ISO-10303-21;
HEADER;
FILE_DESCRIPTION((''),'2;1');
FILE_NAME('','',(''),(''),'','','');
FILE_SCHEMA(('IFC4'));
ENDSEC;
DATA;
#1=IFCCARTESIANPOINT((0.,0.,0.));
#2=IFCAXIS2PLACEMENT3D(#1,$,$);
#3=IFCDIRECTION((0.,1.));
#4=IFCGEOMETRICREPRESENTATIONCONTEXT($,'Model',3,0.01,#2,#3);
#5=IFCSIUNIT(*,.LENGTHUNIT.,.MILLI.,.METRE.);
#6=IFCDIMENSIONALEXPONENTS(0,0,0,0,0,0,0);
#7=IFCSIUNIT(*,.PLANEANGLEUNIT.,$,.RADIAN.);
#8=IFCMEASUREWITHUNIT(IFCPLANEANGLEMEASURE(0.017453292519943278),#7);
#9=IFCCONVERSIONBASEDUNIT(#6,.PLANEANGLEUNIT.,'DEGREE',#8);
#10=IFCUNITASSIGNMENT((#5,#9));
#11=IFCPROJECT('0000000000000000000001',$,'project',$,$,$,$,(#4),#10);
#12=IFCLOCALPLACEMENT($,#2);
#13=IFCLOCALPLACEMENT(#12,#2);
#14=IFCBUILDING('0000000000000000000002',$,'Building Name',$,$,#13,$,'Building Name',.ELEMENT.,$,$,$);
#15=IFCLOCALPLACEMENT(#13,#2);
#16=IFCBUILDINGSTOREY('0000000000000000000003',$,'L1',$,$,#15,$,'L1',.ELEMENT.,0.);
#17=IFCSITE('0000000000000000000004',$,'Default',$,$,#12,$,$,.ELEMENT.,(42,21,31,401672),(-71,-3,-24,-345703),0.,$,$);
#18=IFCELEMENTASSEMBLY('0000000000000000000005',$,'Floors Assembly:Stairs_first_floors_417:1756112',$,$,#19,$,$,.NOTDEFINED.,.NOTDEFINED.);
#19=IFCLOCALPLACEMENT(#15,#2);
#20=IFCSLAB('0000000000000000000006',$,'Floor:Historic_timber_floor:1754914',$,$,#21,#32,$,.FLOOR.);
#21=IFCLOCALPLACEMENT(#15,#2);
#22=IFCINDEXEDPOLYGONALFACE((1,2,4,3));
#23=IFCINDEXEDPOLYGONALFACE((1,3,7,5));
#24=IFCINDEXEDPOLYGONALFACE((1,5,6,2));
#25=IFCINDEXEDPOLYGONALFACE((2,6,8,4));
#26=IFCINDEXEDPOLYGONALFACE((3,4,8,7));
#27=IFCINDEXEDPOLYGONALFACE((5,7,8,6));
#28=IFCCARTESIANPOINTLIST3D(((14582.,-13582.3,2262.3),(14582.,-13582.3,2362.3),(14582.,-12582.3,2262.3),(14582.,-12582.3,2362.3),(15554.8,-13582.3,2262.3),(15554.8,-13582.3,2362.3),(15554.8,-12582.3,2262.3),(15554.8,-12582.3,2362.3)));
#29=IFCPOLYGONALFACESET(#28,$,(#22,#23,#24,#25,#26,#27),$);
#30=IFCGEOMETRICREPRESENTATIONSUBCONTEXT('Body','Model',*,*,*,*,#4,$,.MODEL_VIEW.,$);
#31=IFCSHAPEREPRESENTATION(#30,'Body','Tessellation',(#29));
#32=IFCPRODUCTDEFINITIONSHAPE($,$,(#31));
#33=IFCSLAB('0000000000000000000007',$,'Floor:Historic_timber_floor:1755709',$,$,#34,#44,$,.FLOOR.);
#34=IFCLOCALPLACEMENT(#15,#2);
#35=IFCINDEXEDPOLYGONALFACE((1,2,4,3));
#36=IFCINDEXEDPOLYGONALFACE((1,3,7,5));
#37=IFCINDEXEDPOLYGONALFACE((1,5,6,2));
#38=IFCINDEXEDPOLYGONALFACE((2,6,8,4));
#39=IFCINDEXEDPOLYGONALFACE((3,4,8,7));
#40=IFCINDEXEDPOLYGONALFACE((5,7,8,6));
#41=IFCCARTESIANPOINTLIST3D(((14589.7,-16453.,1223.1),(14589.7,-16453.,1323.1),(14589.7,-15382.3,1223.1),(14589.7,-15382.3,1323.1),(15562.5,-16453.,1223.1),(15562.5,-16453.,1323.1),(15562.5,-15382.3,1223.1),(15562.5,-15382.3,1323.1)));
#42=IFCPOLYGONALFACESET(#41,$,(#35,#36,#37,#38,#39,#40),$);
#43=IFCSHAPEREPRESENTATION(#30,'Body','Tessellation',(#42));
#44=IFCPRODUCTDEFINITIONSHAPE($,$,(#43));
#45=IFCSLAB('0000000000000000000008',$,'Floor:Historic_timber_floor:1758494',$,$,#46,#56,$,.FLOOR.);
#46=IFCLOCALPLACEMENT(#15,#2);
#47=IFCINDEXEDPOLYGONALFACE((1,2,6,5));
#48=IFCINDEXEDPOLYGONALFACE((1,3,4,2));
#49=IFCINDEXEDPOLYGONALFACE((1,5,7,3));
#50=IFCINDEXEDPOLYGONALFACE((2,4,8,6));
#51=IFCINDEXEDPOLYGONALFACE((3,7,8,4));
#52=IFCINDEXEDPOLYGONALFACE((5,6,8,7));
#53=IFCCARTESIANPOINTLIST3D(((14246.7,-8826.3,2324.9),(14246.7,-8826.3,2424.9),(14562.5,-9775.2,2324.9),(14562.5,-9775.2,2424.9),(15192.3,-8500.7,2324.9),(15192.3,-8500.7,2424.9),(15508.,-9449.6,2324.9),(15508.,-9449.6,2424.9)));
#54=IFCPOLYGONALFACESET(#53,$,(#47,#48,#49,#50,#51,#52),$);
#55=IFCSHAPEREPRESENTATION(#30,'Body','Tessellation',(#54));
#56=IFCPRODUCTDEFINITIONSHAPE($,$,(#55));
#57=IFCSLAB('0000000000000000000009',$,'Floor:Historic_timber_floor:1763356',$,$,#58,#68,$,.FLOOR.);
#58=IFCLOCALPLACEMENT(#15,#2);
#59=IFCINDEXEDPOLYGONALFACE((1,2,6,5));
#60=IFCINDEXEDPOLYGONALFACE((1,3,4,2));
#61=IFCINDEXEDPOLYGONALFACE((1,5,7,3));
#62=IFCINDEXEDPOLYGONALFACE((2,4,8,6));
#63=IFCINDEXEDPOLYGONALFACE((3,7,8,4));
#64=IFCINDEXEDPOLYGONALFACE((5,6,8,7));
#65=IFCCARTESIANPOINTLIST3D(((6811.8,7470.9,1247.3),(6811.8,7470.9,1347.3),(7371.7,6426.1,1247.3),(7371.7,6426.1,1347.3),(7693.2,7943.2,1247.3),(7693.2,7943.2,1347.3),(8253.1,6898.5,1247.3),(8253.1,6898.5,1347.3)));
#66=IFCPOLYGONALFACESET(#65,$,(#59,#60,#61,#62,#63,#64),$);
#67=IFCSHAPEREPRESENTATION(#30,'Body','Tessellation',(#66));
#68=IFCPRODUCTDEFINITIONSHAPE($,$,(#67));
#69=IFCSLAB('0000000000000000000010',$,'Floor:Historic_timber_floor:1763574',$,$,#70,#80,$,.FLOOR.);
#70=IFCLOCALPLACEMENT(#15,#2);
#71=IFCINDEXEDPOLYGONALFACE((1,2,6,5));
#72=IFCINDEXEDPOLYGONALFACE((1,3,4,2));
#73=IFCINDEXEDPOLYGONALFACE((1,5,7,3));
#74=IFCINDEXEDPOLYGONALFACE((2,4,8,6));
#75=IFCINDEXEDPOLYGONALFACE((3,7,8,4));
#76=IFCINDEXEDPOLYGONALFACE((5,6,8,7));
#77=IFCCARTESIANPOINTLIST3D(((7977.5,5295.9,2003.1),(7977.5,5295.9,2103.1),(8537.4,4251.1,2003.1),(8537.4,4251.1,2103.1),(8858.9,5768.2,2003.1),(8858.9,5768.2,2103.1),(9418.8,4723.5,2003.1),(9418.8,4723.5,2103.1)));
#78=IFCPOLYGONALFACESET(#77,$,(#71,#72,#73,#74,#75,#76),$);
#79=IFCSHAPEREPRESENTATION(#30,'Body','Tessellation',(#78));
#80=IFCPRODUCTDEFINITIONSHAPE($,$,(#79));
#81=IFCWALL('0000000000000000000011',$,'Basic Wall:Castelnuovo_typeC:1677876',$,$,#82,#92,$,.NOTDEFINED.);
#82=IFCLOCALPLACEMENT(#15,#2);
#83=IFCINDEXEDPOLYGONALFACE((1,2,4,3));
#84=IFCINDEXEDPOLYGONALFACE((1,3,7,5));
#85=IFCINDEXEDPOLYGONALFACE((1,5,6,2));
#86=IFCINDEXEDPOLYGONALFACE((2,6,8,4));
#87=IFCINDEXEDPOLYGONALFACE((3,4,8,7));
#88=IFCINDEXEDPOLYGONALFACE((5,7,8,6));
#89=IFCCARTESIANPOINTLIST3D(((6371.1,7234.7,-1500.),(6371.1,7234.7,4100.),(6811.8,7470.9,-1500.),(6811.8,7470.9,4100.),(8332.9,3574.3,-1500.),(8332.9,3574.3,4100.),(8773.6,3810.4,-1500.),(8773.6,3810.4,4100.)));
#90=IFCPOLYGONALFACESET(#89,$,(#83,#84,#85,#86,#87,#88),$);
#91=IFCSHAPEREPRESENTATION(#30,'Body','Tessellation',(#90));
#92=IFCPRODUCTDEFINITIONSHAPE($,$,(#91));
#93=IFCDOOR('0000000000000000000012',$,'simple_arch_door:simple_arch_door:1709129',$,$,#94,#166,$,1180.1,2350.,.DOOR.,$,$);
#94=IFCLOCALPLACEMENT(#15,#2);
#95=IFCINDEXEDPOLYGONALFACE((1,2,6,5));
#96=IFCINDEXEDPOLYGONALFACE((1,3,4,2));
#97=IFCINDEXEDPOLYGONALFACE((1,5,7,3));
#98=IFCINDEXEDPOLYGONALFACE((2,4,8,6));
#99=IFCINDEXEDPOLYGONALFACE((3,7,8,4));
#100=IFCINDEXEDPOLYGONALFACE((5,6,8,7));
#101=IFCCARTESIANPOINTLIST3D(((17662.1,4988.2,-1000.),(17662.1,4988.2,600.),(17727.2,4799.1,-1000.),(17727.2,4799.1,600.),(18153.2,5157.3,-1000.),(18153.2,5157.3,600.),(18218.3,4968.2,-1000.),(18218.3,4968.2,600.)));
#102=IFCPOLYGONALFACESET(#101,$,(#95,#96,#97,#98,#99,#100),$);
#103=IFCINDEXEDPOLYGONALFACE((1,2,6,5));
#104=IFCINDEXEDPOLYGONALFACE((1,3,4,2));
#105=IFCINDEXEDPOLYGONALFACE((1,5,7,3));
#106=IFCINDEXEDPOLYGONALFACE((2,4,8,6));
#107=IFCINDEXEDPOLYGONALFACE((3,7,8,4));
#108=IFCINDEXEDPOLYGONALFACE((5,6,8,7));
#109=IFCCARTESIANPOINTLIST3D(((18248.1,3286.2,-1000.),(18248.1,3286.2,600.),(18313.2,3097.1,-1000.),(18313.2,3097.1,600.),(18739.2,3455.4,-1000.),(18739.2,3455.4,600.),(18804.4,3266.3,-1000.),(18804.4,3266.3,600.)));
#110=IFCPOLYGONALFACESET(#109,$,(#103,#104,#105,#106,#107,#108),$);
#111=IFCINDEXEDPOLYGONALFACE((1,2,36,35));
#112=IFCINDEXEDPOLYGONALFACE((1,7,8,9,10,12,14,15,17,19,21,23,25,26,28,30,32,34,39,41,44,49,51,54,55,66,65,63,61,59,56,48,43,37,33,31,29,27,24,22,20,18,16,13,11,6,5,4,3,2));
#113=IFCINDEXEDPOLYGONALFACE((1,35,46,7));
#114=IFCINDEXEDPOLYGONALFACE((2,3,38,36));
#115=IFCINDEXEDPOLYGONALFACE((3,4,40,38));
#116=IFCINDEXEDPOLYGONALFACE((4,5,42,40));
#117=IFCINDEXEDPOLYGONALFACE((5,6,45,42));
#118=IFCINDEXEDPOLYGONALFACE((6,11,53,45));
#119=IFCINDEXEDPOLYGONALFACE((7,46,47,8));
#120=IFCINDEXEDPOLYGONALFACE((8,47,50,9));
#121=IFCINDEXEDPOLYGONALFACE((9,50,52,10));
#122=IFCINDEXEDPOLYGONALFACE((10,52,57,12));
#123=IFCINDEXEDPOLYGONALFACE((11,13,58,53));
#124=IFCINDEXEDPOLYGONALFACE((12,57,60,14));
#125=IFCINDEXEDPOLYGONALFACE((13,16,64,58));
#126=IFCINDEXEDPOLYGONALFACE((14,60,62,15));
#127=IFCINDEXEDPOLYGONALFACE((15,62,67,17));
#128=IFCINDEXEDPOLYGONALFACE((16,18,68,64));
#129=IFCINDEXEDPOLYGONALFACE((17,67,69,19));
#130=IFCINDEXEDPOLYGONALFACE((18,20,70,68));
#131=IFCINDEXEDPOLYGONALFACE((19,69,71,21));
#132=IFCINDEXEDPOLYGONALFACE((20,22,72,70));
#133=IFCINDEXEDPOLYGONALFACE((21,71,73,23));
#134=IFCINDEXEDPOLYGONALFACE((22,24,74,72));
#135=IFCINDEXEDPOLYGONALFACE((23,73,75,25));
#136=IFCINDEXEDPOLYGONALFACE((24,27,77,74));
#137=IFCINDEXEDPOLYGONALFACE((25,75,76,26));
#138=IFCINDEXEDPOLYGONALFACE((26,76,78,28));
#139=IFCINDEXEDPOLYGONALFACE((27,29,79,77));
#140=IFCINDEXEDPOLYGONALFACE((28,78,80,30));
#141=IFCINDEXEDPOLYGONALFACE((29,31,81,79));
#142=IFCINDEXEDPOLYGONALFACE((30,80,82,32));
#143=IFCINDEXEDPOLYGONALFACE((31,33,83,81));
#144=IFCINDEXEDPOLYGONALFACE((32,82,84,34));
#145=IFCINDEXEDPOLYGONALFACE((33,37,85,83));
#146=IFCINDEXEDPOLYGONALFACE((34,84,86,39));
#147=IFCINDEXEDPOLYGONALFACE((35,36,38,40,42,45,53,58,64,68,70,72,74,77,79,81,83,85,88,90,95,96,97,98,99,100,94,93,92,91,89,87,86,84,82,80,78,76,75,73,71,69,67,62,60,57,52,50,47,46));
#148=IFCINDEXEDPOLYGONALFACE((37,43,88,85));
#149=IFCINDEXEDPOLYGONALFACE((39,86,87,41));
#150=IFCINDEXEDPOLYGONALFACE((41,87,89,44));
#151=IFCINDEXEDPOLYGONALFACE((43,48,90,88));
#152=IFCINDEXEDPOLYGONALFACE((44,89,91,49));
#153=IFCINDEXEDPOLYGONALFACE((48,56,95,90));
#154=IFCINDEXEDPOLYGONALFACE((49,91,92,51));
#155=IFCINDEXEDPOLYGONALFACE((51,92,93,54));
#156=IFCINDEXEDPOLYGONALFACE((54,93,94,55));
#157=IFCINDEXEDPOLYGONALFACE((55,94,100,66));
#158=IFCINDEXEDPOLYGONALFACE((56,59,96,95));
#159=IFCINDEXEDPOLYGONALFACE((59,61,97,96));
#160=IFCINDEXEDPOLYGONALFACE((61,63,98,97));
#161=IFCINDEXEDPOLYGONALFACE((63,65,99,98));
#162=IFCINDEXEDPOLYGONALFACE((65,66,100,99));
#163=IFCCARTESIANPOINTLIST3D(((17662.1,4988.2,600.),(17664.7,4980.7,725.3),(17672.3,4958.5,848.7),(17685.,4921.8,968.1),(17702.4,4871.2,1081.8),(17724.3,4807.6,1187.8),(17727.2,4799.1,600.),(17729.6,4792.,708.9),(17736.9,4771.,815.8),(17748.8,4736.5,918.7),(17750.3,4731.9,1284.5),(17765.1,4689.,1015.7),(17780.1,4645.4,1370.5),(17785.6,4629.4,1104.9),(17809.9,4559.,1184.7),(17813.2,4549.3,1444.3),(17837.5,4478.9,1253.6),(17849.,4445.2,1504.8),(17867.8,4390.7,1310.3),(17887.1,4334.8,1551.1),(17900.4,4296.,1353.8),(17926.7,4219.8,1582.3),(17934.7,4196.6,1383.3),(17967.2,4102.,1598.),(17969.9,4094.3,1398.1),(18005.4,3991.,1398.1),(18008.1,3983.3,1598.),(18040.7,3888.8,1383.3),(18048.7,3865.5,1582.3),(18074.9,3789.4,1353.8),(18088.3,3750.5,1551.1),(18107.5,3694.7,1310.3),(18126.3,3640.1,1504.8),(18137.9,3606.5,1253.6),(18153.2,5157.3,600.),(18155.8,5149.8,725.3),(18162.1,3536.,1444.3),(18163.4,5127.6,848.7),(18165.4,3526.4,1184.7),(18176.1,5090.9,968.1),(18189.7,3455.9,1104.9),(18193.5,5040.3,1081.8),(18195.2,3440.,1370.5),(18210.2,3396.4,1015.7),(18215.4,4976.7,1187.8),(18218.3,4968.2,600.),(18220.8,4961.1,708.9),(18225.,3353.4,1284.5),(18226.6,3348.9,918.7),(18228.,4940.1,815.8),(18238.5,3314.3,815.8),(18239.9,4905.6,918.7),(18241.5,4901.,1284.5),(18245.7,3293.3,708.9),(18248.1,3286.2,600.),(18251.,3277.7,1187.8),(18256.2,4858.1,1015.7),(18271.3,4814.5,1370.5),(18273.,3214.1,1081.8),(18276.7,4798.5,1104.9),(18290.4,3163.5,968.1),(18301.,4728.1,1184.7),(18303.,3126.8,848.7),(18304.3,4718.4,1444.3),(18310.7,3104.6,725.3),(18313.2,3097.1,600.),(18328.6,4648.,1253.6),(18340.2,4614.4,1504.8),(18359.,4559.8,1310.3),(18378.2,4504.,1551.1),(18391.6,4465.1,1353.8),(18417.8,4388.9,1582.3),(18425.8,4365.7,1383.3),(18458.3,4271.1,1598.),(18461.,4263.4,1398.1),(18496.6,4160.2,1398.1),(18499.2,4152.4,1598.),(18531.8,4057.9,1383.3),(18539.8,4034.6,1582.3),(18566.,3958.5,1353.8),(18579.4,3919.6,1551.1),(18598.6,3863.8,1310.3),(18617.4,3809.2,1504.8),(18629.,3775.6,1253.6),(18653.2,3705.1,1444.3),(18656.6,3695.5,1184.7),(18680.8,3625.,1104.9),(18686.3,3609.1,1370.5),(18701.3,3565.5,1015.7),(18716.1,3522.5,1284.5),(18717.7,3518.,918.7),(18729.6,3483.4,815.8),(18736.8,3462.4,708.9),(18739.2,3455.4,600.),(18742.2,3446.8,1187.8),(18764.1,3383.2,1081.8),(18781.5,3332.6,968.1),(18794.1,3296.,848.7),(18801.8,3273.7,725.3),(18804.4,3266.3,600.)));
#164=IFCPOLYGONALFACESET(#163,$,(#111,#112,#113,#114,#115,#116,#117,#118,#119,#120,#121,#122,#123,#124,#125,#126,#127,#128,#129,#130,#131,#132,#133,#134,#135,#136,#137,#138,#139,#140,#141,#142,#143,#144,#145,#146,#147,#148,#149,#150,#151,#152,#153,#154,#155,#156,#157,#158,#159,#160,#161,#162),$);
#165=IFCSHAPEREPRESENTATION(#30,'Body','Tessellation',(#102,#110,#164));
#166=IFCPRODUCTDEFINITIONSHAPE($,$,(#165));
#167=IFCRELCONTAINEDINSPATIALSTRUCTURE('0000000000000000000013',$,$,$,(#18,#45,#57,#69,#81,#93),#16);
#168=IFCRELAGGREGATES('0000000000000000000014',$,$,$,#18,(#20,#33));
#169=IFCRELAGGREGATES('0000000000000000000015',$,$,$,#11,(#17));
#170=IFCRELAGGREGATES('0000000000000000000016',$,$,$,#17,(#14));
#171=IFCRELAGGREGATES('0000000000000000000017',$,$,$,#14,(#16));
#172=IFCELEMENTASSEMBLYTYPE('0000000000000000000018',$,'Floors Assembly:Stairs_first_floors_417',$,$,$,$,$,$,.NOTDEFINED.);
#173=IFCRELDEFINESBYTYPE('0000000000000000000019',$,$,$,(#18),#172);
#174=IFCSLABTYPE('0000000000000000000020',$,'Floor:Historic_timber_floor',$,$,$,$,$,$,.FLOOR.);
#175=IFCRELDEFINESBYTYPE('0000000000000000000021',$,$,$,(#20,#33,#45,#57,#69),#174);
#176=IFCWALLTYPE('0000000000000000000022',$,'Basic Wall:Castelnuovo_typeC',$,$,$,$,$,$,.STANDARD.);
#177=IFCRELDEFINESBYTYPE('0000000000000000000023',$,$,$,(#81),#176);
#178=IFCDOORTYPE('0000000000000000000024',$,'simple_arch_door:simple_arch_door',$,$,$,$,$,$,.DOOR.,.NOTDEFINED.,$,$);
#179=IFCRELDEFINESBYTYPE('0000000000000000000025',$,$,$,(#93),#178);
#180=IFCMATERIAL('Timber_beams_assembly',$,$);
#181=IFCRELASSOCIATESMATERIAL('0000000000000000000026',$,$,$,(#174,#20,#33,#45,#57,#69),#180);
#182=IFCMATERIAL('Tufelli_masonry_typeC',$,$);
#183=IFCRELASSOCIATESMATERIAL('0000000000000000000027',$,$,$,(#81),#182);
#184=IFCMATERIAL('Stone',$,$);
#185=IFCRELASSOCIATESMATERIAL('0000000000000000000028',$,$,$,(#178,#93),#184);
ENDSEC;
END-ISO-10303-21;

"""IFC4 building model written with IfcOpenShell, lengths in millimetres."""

from ifc_helpers import new_model, entity, si_unit, converted_unit, direction, frame, origin, place, context, subcontext, project, spatial, line, arc, indexed_curve, outline, extrude, source, transform, mapped, material, type_object, type_shapes, element, aggregate, save


model = new_model("IFC4")

# Units and contexts
model_context = context("Model", 3, precision=0.01, world=origin(), true_north=direction((0.0, 1.0)))
body_context = subcontext(model_context, "Body", "Model", "MODEL_VIEW")
ifc_project = project(units=[si_unit("LENGTHUNIT", "METRE", prefix="MILLI"), converted_unit("PLANEANGLEUNIT", "DEGREE", entity("IfcPlaneAngleMeasure", 0.017453292519943278), si_unit("PLANEANGLEUNIT", "RADIAN"), dimensions=[0, 0, 0, 0, 0, 0, 0])], contexts=[model_context])

# Site, building, storey
site_placement = place(None, origin())
site = spatial("IfcSite", under=ifc_project, at=site_placement, Name="Default", CompositionType="ELEMENT", RefLatitude=(42, 21, 31, 401672), RefLongitude=(-71, -3, -24, -345703), RefElevation=0.0)
building_placement = place(site_placement, origin())
building = spatial("IfcBuilding", under=site, at=building_placement, Name="Building Name", LongName="Building Name", CompositionType="ELEMENT")
storey_placement = place(building_placement, origin())
storey = spatial("IfcBuildingStorey", under=building, at=storey_placement, Name="L1", LongName="L1", CompositionType="ELEMENT", Elevation=0.0)

# Element assembly, slabs
element_assembly_type = type_object("IfcElementAssemblyType", Name="Floors Assembly:Stairs_first_floors_417", PredefinedType="NOTDEFINED")
assembly_placement = place(storey_placement, origin())
assembly = element("IfcElementAssembly", 1, at=assembly_placement, inside=storey, type_object=element_assembly_type, Name="Floors Assembly:Stairs_first_floors_417:1756112", AssemblyPlace="NOTDEFINED", PredefinedType="NOTDEFINED")
ifc_material_1 = material(Name="Timber_beams_assembly")
slab_type = type_object("IfcSlabType", Name="Floor:Historic_timber_floor", PredefinedType="FLOOR", material=ifc_material_1)
slab_1_placement = place(assembly_placement, frame((0.0, 0.0, 4100.0)))
slab_1 = element("IfcSlab", 2, at=slab_1_placement, type_object=slab_type, material=ifc_material_1, Name="Floor:Historic_timber_floor:1754914", PredefinedType="FLOOR", context=body_context, shape_type="SweptSolid", body=[
    extrude(outline(indexed_curve([(-500.0, -486.4), (500.0, -486.4), (500.0, 486.4), (-500.0, 486.4), (-500.0, -486.4)], self_intersect=False)), frame((15068.4, -13082.3, -1737.7), z_axis=(0.0, 0.0, -1.0), x_axis=(0.0, 1.0, 0.0)), (0.0, 0.0, 1.0), 100.0),
])
slab_2_placement = place(assembly_placement, origin())
slab_2 = element("IfcSlab", 3, at=slab_2_placement, type_object=slab_type, material=ifc_material_1, Name="Floor:Historic_timber_floor:1755709", PredefinedType="FLOOR", context=body_context, shape_type="SweptSolid", body=[
    extrude(outline(indexed_curve([(-535.3, -486.4), (535.3, -486.4), (535.3, 486.4), (-535.3, 486.4), (-535.3, -486.4)], self_intersect=False)), frame((15076.1, -15917.7, 1323.1), z_axis=(0.0, 0.0, -1.0), x_axis=(0.0, 1.0, 0.0)), (0.0, 0.0, 1.0), 100.0),
])
aggregate(assembly, [slab_1, slab_2])

# Slabs
slab_3_placement = place(storey_placement, origin())
element("IfcSlab", 4, at=slab_3_placement, inside=storey, type_object=slab_type, material=ifc_material_1, Name="Floor:Historic_timber_floor:1758494", PredefinedType="FLOOR", context=body_context, shape_type="SweptSolid", body=[
    extrude(outline(indexed_curve([(-505.2, -500.0), (494.8, -500.0), (505.2, 500.0), (-494.8, 500.0), (-505.2, -500.0)], self_intersect=False)), frame((14877.4, -9137.9, 2424.9), z_axis=(0.0, 0.0, -1.0), x_axis=(0.315716, -0.948854, 0.0)), (0.0, 0.0, 1.0), 100.0),
])
slab_4_placement = place(storey_placement, origin())
element("IfcSlab", 5, at=slab_4_placement, inside=storey, type_object=slab_type, material=ifc_material_1, Name="Floor:Historic_timber_floor:1763356", PredefinedType="FLOOR", context=body_context, shape_type="SweptSolid", body=[
    extrude(outline(indexed_curve([(-592.7, -500.0), (592.7, -500.0), (592.7, 500.0), (-592.7, 500.0), (-592.7, -500.0)], self_intersect=False)), frame((7532.5, 7184.7, 1347.3), z_axis=(0.0, 0.0, -1.0), x_axis=(0.472369, -0.881401, 0.0)), (0.0, 0.0, 1.0), 100.0),
])
slab_5_placement = place(storey_placement, origin())
element("IfcSlab", 6, at=slab_5_placement, inside=storey, type_object=slab_type, material=ifc_material_1, Name="Floor:Historic_timber_floor:1763574", PredefinedType="FLOOR", context=body_context, shape_type="SweptSolid", body=[
    extrude(outline(indexed_curve([(-592.7, -500.0), (592.7, -500.0), (592.7, 500.0), (-592.7, 500.0), (-592.7, -500.0)], self_intersect=False)), frame((8698.1, 5009.7, 2103.1), z_axis=(0.0, 0.0, -1.0), x_axis=(0.472369, -0.881401, 0.0)), (0.0, 0.0, 1.0), 100.0),
])

# Wall
ifc_material_2 = material(Name="Tufelli_masonry_typeC")
wall_type_1 = type_object("IfcWallType", Name="Basic Wall:Castelnuovo_typeC", PredefinedType="STANDARD")
wall_1_placement = place(storey_placement, frame((8553.2, 3692.4, -1500.0), z_axis=(0.0, 0.0, 1.0), x_axis=(-0.472369, 0.881401, 0.0)))
element("IfcWall", 7, at=wall_1_placement, inside=storey, type_object=wall_type_1, material=ifc_material_2, Name="Basic Wall:Castelnuovo_typeC:1677876", PredefinedType="NOTDEFINED", context=body_context, shape_type="SweptSolid", body=[
    extrude(outline(indexed_curve([(4153.0, 250.0), (0.0, 250.0), (0.0, -250.0), (4153.0, -250.0), (4153.0, 250.0)], self_intersect=False)), origin(), (0.0, 0.0, 1.0), 5600.0),
])

# Door
ifc_material_3 = material(Name="Stone")
door_type_1 = type_object("IfcDoorType", Name="simple_arch_door:simple_arch_door", OperationType="NOTDEFINED", PredefinedType="DOOR", material=ifc_material_3)
shared_shape_1 = source(origin(), body_context, "Body", "SweptSolid", [
    extrude(outline(indexed_curve([(-100.0, -259.7), (100.0, -259.7), (100.0, 259.7), (-100.0, 259.7), (-100.0, -259.7)], self_intersect=False)), frame((900.0, 0.0, 0.0), z_axis=(0.0, 0.0, 1.0), x_axis=(-1.0, 0.0, 0.0)), (0.0, 0.0, 1.0), 1600.0),
    extrude(outline(indexed_curve([(-100.0, -259.7), (100.0, -259.7), (100.0, 259.7), (-100.0, 259.7), (-100.0, -259.7)], self_intersect=False)), frame((-900.0, 0.0, 0.0), z_axis=(0.0, 0.0, 1.0), x_axis=(-1.0, 0.0, 0.0)), (0.0, 0.0, 1.0), 1600.0),
    extrude(outline(indexed_curve([(-1000.0, 0.0), (0.0, -1000.0), (1000.0, 0.0), (800.0, 0.0), (0.0, -800.0), (-800.0, 0.0)], segments=[arc(1, 2, 3), line(3, 4), arc(4, 5, 6), line(6, 1)], self_intersect=False)), frame((0.0, -259.7, 1600.0), z_axis=(0.0, 1.0, 0.0), x_axis=(1.0, 0.0, 0.0)), (0.0, 0.0, 1.0), 519.4),
])
type_shapes(door_type_1, [shared_shape_1])
door_1_placement = place(storey_placement, frame((18233.2, 4127.2, -1000.0), z_axis=(0.0, 0.0, 1.0), x_axis=(-0.325568, 0.945519, 0.0)))
element("IfcDoor", 8, at=door_1_placement, inside=storey, type_object=door_type_1, material=ifc_material_3, Name="simple_arch_door:simple_arch_door:1709129", OverallHeight=1180.1, OverallWidth=2350.0, PredefinedType="DOOR", context=body_context, shape_type="MappedRepresentation", body=[
    mapped(shared_shape_1, transform((0.0, 0.0, 0.0), scale=1.0)),
])

save(model, "model.ifc")
